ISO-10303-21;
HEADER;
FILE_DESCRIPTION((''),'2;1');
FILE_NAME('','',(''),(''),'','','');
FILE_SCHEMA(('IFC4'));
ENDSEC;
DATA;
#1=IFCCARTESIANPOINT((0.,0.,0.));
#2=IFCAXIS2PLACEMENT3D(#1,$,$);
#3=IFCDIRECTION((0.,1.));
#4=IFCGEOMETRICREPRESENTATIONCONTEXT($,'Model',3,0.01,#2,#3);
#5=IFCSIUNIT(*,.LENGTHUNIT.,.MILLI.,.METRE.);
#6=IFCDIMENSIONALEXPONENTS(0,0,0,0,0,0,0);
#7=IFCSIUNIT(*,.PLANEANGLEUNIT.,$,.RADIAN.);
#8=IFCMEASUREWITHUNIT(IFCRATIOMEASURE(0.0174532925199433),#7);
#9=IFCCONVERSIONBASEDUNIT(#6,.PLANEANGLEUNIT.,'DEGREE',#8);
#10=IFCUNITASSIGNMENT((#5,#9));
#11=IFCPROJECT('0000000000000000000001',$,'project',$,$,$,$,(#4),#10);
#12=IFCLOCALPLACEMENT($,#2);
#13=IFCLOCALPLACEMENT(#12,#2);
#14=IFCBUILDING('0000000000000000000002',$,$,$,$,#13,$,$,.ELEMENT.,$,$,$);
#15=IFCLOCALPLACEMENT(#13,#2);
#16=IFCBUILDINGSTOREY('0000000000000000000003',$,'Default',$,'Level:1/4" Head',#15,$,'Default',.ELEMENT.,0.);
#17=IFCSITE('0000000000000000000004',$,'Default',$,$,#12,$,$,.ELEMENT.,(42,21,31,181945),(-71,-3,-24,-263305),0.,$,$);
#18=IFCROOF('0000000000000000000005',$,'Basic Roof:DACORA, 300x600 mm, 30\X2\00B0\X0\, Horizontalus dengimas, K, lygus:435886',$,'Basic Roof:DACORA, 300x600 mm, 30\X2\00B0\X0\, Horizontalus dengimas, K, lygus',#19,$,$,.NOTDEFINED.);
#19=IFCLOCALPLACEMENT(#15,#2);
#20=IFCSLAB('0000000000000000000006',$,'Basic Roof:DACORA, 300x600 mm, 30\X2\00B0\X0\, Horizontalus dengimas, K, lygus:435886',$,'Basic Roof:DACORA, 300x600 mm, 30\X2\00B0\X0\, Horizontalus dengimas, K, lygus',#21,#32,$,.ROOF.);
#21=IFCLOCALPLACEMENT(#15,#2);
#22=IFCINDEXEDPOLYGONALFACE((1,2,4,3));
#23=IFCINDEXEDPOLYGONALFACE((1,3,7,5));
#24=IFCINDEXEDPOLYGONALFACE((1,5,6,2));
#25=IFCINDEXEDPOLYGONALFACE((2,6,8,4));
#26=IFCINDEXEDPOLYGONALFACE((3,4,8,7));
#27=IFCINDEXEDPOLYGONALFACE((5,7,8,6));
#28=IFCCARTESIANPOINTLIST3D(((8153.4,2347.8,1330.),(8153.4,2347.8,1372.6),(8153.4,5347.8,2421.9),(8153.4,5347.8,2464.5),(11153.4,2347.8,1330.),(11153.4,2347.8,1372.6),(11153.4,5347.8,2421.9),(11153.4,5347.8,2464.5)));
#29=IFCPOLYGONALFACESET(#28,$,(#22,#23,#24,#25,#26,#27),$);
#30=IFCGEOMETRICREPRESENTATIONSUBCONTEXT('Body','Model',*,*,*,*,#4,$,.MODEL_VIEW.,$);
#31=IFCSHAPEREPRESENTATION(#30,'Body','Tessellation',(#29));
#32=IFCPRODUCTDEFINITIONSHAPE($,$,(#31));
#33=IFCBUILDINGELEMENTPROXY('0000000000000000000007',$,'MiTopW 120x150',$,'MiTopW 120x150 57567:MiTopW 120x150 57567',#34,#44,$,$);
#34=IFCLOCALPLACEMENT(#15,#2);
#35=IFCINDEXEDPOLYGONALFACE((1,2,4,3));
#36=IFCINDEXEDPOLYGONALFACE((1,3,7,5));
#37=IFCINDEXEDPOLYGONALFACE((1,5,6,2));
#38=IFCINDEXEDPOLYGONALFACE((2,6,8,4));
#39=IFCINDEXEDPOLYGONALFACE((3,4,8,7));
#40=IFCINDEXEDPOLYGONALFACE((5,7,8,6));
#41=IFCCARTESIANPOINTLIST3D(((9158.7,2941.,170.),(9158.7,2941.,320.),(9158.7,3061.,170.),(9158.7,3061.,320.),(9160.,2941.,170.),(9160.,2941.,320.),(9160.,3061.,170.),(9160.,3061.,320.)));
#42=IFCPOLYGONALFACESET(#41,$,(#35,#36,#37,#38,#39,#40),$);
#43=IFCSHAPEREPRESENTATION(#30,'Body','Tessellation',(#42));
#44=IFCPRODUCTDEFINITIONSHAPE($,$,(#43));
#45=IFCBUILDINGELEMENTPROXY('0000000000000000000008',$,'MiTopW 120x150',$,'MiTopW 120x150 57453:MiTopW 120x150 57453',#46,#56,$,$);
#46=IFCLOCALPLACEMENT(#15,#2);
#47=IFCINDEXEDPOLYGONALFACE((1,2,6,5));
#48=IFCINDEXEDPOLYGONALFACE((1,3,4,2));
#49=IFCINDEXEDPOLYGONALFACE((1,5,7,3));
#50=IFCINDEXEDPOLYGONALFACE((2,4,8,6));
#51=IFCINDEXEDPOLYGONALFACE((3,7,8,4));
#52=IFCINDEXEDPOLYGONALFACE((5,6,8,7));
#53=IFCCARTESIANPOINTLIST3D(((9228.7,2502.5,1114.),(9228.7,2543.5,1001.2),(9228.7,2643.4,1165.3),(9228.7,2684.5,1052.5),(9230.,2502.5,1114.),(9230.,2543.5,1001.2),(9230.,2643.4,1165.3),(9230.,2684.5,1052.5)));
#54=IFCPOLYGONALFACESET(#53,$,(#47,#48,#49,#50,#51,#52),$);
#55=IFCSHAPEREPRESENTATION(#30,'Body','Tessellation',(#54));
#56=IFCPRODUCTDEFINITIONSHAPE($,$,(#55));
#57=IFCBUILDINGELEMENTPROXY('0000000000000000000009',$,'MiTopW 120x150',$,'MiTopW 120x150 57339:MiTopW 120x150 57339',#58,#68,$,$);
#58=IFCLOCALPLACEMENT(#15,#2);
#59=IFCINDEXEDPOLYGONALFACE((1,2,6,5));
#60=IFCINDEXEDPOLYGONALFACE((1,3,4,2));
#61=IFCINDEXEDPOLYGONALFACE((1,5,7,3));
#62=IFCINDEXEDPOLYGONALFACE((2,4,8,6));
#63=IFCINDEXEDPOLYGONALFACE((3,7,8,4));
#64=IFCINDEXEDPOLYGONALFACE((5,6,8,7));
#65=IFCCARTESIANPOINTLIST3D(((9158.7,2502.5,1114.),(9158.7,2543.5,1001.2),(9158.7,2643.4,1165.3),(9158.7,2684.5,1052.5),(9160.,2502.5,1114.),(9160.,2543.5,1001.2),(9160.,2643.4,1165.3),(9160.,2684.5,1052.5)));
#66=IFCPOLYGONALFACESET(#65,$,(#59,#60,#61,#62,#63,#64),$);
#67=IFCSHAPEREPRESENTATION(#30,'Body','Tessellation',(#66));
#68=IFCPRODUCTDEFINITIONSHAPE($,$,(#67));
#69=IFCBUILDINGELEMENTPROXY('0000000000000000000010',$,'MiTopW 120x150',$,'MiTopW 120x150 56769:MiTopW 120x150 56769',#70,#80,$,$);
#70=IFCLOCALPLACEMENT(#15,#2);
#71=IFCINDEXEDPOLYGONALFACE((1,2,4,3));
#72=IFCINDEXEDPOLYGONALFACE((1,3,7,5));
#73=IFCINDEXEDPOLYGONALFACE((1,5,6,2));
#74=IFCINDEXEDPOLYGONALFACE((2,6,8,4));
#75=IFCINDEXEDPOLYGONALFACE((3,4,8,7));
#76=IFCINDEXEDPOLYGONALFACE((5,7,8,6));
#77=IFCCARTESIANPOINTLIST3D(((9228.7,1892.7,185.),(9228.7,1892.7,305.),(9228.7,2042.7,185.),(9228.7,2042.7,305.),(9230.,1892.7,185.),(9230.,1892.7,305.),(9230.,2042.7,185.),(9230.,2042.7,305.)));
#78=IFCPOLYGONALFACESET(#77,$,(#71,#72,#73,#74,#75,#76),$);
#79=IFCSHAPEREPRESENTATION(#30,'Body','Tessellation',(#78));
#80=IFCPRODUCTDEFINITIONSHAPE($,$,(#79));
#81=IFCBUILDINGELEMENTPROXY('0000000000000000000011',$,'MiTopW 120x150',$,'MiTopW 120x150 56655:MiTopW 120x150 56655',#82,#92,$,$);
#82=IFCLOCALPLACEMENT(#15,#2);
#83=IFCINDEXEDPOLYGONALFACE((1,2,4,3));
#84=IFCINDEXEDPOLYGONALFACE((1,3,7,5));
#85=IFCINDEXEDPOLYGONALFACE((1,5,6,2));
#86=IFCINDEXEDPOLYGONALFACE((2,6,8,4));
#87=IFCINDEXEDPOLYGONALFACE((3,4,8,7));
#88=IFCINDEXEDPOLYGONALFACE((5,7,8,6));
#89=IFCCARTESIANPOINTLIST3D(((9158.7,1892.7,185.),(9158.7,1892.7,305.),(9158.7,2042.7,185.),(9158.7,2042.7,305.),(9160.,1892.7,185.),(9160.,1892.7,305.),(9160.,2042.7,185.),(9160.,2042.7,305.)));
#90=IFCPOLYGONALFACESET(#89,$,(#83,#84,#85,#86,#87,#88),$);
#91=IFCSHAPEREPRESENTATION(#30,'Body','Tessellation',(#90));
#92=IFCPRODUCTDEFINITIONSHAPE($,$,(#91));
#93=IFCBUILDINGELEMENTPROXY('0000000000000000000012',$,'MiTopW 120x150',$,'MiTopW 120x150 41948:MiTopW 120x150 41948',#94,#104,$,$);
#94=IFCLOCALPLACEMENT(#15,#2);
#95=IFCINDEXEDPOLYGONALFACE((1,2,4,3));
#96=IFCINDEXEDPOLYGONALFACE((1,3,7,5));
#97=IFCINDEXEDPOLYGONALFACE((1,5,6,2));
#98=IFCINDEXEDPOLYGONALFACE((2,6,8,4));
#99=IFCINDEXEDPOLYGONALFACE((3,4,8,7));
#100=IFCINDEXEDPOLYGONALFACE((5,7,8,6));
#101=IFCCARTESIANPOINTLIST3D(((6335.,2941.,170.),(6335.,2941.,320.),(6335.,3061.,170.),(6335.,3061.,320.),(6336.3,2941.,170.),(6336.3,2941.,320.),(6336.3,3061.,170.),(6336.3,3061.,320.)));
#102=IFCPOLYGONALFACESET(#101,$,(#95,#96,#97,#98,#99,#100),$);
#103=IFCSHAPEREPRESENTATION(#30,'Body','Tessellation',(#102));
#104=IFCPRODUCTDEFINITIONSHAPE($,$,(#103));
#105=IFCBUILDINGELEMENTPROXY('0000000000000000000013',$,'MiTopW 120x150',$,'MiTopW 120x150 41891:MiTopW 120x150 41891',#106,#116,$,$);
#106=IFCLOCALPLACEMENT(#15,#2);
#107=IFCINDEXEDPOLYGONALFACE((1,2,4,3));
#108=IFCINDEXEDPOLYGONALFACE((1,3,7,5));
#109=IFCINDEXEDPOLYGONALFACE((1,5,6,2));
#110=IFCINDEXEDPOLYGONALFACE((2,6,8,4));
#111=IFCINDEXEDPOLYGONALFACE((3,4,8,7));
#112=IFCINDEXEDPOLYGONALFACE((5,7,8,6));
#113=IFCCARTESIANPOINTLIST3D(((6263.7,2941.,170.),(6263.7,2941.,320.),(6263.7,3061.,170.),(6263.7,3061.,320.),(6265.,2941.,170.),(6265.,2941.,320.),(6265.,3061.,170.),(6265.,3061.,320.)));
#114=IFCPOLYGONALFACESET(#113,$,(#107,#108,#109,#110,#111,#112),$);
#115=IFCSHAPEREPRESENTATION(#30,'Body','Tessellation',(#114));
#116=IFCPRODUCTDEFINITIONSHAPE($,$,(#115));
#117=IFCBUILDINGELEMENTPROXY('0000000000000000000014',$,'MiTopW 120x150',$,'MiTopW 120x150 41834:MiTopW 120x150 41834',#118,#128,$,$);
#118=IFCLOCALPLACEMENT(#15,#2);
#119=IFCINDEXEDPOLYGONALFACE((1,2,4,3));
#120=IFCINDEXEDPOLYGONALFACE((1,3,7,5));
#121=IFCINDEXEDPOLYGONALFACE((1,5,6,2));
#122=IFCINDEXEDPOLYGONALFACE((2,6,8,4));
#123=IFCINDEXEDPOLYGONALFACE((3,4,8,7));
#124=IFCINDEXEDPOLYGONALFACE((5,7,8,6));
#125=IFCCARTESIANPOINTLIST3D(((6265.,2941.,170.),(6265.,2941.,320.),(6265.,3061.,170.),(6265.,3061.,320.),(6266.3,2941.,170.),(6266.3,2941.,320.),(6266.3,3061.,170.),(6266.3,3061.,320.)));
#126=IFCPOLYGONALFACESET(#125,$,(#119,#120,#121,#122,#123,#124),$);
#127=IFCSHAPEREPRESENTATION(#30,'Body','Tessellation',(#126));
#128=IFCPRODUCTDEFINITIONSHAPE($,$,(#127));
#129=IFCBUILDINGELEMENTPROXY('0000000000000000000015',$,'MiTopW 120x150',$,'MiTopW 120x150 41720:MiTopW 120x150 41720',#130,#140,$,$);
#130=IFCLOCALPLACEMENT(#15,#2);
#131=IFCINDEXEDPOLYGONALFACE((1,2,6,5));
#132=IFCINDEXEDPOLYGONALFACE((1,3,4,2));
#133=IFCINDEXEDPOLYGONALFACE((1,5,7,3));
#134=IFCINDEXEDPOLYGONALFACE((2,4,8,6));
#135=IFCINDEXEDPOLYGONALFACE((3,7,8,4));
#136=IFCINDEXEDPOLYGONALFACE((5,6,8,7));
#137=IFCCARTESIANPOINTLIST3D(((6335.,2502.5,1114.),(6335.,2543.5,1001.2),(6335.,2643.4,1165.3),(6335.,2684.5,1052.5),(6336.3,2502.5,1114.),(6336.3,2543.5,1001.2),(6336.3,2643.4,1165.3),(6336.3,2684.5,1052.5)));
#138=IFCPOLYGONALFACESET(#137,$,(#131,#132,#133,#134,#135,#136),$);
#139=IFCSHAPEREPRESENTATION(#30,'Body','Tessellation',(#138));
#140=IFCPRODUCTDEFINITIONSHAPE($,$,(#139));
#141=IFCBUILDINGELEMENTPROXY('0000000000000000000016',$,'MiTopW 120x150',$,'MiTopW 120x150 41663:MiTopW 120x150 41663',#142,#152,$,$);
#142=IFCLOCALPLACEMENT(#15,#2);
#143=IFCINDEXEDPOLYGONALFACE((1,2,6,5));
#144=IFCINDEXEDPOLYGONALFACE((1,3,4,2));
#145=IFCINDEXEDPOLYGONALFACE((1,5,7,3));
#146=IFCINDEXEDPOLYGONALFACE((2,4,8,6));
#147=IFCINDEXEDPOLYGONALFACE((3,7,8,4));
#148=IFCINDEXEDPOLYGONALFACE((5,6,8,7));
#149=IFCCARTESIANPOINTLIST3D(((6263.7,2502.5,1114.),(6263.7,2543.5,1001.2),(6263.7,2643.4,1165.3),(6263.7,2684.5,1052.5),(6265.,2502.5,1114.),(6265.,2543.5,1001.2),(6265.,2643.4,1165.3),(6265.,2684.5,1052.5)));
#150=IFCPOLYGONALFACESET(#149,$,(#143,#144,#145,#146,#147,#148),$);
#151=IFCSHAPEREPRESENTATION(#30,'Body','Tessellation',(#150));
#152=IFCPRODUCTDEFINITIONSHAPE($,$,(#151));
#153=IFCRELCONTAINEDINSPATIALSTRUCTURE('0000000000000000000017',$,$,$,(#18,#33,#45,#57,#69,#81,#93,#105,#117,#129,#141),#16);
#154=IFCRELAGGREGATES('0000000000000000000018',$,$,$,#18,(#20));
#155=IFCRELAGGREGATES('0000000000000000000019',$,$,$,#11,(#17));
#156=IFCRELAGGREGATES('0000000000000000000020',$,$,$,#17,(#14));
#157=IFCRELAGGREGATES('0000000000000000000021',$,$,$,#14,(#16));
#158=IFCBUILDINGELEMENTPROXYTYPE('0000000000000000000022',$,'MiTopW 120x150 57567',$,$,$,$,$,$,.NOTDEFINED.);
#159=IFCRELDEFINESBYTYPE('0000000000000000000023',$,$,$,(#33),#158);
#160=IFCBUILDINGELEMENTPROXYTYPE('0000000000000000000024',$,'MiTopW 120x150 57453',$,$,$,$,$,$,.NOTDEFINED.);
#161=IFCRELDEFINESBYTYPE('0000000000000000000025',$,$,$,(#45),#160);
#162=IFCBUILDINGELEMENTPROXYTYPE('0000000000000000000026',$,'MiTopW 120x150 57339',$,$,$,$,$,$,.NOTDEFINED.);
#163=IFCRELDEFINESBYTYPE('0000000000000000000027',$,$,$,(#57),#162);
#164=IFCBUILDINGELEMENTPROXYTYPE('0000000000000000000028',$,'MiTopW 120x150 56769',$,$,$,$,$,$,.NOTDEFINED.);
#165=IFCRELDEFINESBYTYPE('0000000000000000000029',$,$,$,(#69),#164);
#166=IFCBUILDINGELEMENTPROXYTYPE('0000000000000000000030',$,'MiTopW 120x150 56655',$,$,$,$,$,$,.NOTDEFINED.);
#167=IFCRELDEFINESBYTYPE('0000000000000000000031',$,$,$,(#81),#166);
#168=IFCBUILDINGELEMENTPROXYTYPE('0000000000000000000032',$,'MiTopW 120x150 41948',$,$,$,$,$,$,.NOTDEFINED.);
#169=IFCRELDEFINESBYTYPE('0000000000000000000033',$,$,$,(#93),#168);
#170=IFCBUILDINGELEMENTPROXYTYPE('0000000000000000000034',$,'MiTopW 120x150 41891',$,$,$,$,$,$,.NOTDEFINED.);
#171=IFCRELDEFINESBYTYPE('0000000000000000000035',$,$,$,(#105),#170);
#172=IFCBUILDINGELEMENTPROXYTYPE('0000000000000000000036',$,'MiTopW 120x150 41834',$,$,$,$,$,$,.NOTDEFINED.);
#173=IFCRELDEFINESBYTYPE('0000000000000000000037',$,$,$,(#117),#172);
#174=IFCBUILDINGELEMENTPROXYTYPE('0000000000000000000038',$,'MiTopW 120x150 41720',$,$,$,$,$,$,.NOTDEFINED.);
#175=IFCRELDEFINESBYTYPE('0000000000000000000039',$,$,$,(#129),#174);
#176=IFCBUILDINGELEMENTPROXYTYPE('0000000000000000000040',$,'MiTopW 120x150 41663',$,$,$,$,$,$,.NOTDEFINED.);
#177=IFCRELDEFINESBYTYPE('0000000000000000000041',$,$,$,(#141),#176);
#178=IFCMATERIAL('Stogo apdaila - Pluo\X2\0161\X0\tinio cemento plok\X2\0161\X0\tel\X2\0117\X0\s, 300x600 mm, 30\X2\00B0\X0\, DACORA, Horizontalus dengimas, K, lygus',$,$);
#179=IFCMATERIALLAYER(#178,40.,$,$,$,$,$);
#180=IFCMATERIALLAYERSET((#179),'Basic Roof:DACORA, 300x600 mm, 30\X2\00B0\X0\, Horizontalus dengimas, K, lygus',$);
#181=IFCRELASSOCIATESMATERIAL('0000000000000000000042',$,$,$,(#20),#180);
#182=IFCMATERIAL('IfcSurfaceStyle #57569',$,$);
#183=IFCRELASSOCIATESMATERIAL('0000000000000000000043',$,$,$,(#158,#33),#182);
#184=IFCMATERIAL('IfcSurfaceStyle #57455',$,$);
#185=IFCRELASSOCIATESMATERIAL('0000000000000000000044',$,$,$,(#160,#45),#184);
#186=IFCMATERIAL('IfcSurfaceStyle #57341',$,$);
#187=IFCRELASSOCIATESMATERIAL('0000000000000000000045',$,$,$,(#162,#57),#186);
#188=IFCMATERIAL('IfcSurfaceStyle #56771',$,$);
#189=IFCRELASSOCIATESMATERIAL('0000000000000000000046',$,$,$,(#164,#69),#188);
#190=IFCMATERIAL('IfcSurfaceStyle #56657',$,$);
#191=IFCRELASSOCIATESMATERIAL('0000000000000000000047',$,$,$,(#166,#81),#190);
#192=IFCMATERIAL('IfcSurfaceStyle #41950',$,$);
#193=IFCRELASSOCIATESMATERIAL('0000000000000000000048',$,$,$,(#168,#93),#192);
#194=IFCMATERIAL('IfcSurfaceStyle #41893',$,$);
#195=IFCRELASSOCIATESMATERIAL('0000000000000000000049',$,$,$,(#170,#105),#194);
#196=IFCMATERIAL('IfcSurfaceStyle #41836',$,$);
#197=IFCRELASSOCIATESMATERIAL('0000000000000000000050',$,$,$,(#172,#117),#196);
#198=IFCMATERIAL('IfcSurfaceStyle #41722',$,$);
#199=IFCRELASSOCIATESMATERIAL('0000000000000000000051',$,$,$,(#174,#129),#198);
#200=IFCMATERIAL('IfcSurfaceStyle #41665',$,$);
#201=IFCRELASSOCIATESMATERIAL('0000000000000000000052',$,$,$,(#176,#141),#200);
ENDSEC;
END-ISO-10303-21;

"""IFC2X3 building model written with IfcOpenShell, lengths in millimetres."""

from ifc_helpers import new_model, entity, si_unit, converted_unit, direction, frame, frame_2d, origin, origin_2d_with_axis, place, context, subcontext, project, spatial, polyline, rectangle, outline, extrude, source, transform, mapped, material, layer, layer_set, type_object, type_shapes, element, aggregate, save


model = new_model("IFC2X3")

# Units and contexts
model_context = context("Model", 3, precision=0.01, world=origin(), true_north=direction((0.0, 1.0)))
body_context = subcontext(model_context, "Body", "Model", "MODEL_VIEW")
ifc_project = project(units=[si_unit("LENGTHUNIT", "METRE", prefix="MILLI"), converted_unit("PLANEANGLEUNIT", "DEGREE", entity("IfcRatioMeasure", 0.0174532925199433), si_unit("PLANEANGLEUNIT", "RADIAN"), dimensions=[0, 0, 0, 0, 0, 0, 0])], contexts=[model_context])

# Site, building, storey
site_placement = place(None, origin())
site = spatial("IfcSite", under=ifc_project, at=site_placement, Name="Default", CompositionType="ELEMENT", RefLatitude=(42, 21, 31, 181945), RefLongitude=(-71, -3, -24, -263305), RefElevation=0.0)
building_placement = place(site_placement, origin())
building = spatial("IfcBuilding", under=site, at=building_placement, CompositionType="ELEMENT")
storey_placement = place(building_placement, origin())
storey = spatial("IfcBuildingStorey", under=building, at=storey_placement, Name="Default", ObjectType="Level:1/4\" Head", LongName="Default", CompositionType="ELEMENT", Elevation=0.0)

# Roof, slab
roof_placement = place(storey_placement, frame((8153.4, 2347.8, 1330.0)))
roof = element("IfcRoof", 1, at=roof_placement, inside=storey, Name="Basic Roof:DACORA, 300x600 mm, 30°, Horizontalus dengimas, K, lygus:435886", ObjectType="Basic Roof:DACORA, 300x600 mm, 30°, Horizontalus dengimas, K, lygus", ShapeType="NOTDEFINED")
ifc_material_1 = material(Name="Stogo apdaila - Pluoštinio cemento plokštelės, 300x600 mm, 30°, DACORA, Horizontalus dengimas, K, lygus")
ifc_layer = layer(ifc_material_1, 40.0)
ifc_layer_set = layer_set([ifc_layer], Name="Basic Roof:DACORA, 300x600 mm, 30°, Horizontalus dengimas, K, lygus")
slab_placement = place(roof_placement, origin())
slab = element("IfcSlab", 2, at=slab_placement, material=ifc_layer_set, Name="Basic Roof:DACORA, 300x600 mm, 30°, Horizontalus dengimas, K, lygus:435886", ObjectType="Basic Roof:DACORA, 300x600 mm, 30°, Horizontalus dengimas, K, lygus", PredefinedType="ROOF", context=body_context, shape_type="SweptSolid", body=[
    extrude(rectangle(XDim=3192.5, YDim=3000.0, at=frame_2d((0.0, 0.0), x_axis=(0.0, -1.0))), frame((1500.0, 1500.0, 546.0), z_axis=(0.0, -0.34202, 0.939693), x_axis=(1.0, 0.0, 0.0)), (0.0, 0.34202, 0.939693), 42.6),
])
aggregate(roof, [slab])

# Building element proxies
ifc_material_2 = material(Name="IfcSurfaceStyle #57569")
building_element_proxy_type_1 = type_object("IfcBuildingElementProxyType", Name="MiTopW 120x150 57567", PredefinedType="NOTDEFINED", material=ifc_material_2)
shared_shape_1 = source(origin(), body_context, "Body", "SweptSolid", [
    extrude(rectangle(XDim=150.0, YDim=120.0, at=frame_2d((0.0, 0.0), x_axis=(1.0, 0.0))), frame((75.0, 60.0, 0.0), z_axis=(0.0, 0.0, 1.0), x_axis=(-1.0, 0.0, 0.0)), (0.0, 0.0, 1.0), 1.3),
])
type_shapes(building_element_proxy_type_1, [shared_shape_1])
proxy_1_placement = place(building_placement, frame((9160.0, 2941.0, 170.0), z_axis=(-1.0, 0.0, 0.0), x_axis=(0.0, 0.0, 1.0)))
element("IfcBuildingElementProxy", 3, at=proxy_1_placement, inside=storey, type_object=building_element_proxy_type_1, material=ifc_material_2, Name="MiTopW 120x150", ObjectType="MiTopW 120x150 57567:MiTopW 120x150 57567", context=body_context, shape_type="MappedRepresentation", body=[
    mapped(shared_shape_1, transform((0.0, 0.0, 0.0), scale=1.0)),
])
ifc_material_3 = material(Name="IfcSurfaceStyle #57455")
building_element_proxy_type_2 = type_object("IfcBuildingElementProxyType", Name="MiTopW 120x150 57453", PredefinedType="NOTDEFINED", material=ifc_material_3)
shared_shape_2 = source(origin(), body_context, "Body", "SweptSolid", [
    extrude(outline(polyline([(-75.0, -60.0), (75.0, -60.0), (75.0, 60.0), (-75.0, 60.0), (-75.0, -60.0)])), frame((75.0, 60.0, 0.0), z_axis=(0.0, 0.0, 1.0), x_axis=(-1.0, 0.0, 0.0)), (0.0, 0.0, 1.0), 1.3),
])
type_shapes(building_element_proxy_type_2, [shared_shape_2])
proxy_2_placement = place(building_placement, frame((9230.0, 2502.5, 1114.0), z_axis=(-1.0, 0.0, 0.0), x_axis=(0.0, 0.939693, 0.34202)))
element("IfcBuildingElementProxy", 4, at=proxy_2_placement, inside=storey, type_object=building_element_proxy_type_2, material=ifc_material_3, Name="MiTopW 120x150", ObjectType="MiTopW 120x150 57453:MiTopW 120x150 57453", context=body_context, shape_type="MappedRepresentation", body=[
    mapped(shared_shape_2, transform((0.0, 0.0, 0.0), scale=1.0)),
])
ifc_material_4 = material(Name="IfcSurfaceStyle #57341")
building_element_proxy_type_3 = type_object("IfcBuildingElementProxyType", Name="MiTopW 120x150 57339", PredefinedType="NOTDEFINED", material=ifc_material_4)
shared_shape_3 = source(origin(), body_context, "Body", "SweptSolid", [
    extrude(outline(polyline([(-75.0, -60.0), (75.0, -60.0), (75.0, 60.0), (-75.0, 60.0), (-75.0, -60.0)])), frame((75.0, 60.0, 0.0), z_axis=(0.0, 0.0, 1.0), x_axis=(-1.0, 0.0, 0.0)), (0.0, 0.0, 1.0), 1.3),
])
type_shapes(building_element_proxy_type_3, [shared_shape_3])
proxy_3_placement = place(building_placement, frame((9160.0, 2502.5, 1114.0), z_axis=(-1.0, 0.0, 0.0), x_axis=(0.0, 0.939693, 0.34202)))
element("IfcBuildingElementProxy", 5, at=proxy_3_placement, inside=storey, type_object=building_element_proxy_type_3, material=ifc_material_4, Name="MiTopW 120x150", ObjectType="MiTopW 120x150 57339:MiTopW 120x150 57339", context=body_context, shape_type="MappedRepresentation", body=[
    mapped(shared_shape_3, transform((0.0, 0.0, 0.0), scale=1.0)),
])
ifc_material_5 = material(Name="IfcSurfaceStyle #56771")
building_element_proxy_type_4 = type_object("IfcBuildingElementProxyType", Name="MiTopW 120x150 56769", PredefinedType="NOTDEFINED", material=ifc_material_5)
shared_shape_4 = source(origin(), body_context, "Body", "SweptSolid", [
    extrude(rectangle(XDim=150.0, YDim=120.0, at=origin_2d_with_axis()), frame((75.0, 60.0, 0.0), z_axis=(0.0, 0.0, 1.0), x_axis=(-1.0, 0.0, 0.0)), (0.0, 0.0, 1.0), 1.3),
])
type_shapes(building_element_proxy_type_4, [shared_shape_4])
proxy_4_placement = place(building_placement, frame((9230.0, 1892.7, 305.0), z_axis=(-1.0, 0.0, 0.0), x_axis=(0.0, 1.0, 0.0)))
element("IfcBuildingElementProxy", 6, at=proxy_4_placement, inside=storey, type_object=building_element_proxy_type_4, material=ifc_material_5, Name="MiTopW 120x150", ObjectType="MiTopW 120x150 56769:MiTopW 120x150 56769", context=body_context, shape_type="MappedRepresentation", body=[
    mapped(shared_shape_4, transform((0.0, 0.0, 0.0), scale=1.0)),
])
ifc_material_6 = material(Name="IfcSurfaceStyle #56657")
building_element_proxy_type_5 = type_object("IfcBuildingElementProxyType", Name="MiTopW 120x150 56655", PredefinedType="NOTDEFINED", material=ifc_material_6)
shared_shape_5 = source(origin(), body_context, "Body", "SweptSolid", [
    extrude(rectangle(XDim=150.0, YDim=120.0, at=origin_2d_with_axis()), frame((75.0, 60.0, 0.0), z_axis=(0.0, 0.0, 1.0), x_axis=(-1.0, 0.0, 0.0)), (0.0, 0.0, 1.0), 1.3),
])
type_shapes(building_element_proxy_type_5, [shared_shape_5])
proxy_5_placement = place(building_placement, frame((9160.0, 1892.7, 305.0), z_axis=(-1.0, 0.0, 0.0), x_axis=(0.0, 1.0, 0.0)))
element("IfcBuildingElementProxy", 7, at=proxy_5_placement, inside=storey, type_object=building_element_proxy_type_5, material=ifc_material_6, Name="MiTopW 120x150", ObjectType="MiTopW 120x150 56655:MiTopW 120x150 56655", context=body_context, shape_type="MappedRepresentation", body=[
    mapped(shared_shape_5, transform((0.0, 0.0, 0.0), scale=1.0)),
])
ifc_material_7 = material(Name="IfcSurfaceStyle #41950")
building_element_proxy_type_6 = type_object("IfcBuildingElementProxyType", Name="MiTopW 120x150 41948", PredefinedType="NOTDEFINED", material=ifc_material_7)
shared_shape_6 = source(origin(), body_context, "Body", "SweptSolid", [
    extrude(rectangle(XDim=150.0, YDim=120.0, at=frame_2d((0.0, 0.0), x_axis=(1.0, 0.0))), frame((75.0, 60.0, 0.0), z_axis=(0.0, 0.0, 1.0), x_axis=(-1.0, 0.0, 0.0)), (0.0, 0.0, 1.0), 1.3),
])
type_shapes(building_element_proxy_type_6, [shared_shape_6])
proxy_6_placement = place(building_placement, frame((6336.3, 2941.0, 170.0), z_axis=(-1.0, 0.0, 0.0), x_axis=(0.0, 0.0, 1.0)))
element("IfcBuildingElementProxy", 8, at=proxy_6_placement, inside=storey, type_object=building_element_proxy_type_6, material=ifc_material_7, Name="MiTopW 120x150", ObjectType="MiTopW 120x150 41948:MiTopW 120x150 41948", context=body_context, shape_type="MappedRepresentation", body=[
    mapped(shared_shape_6, transform((0.0, 0.0, 0.0), scale=1.0)),
])
ifc_material_8 = material(Name="IfcSurfaceStyle #41893")
building_element_proxy_type_7 = type_object("IfcBuildingElementProxyType", Name="MiTopW 120x150 41891", PredefinedType="NOTDEFINED", material=ifc_material_8)
shared_shape_7 = source(origin(), body_context, "Body", "SweptSolid", [
    extrude(rectangle(XDim=150.0, YDim=120.0, at=frame_2d((0.0, 0.0), x_axis=(1.0, 0.0))), frame((75.0, 60.0, 0.0), z_axis=(0.0, 0.0, 1.0), x_axis=(-1.0, 0.0, 0.0)), (0.0, 0.0, 1.0), 1.3),
])
type_shapes(building_element_proxy_type_7, [shared_shape_7])
proxy_7_placement = place(building_placement, frame((6265.0, 2941.0, 170.0), z_axis=(-1.0, 0.0, 0.0), x_axis=(0.0, 0.0, 1.0)))
element("IfcBuildingElementProxy", 9, at=proxy_7_placement, inside=storey, type_object=building_element_proxy_type_7, material=ifc_material_8, Name="MiTopW 120x150", ObjectType="MiTopW 120x150 41891:MiTopW 120x150 41891", context=body_context, shape_type="MappedRepresentation", body=[
    mapped(shared_shape_7, transform((0.0, 0.0, 0.0), scale=1.0)),
])
ifc_material_9 = material(Name="IfcSurfaceStyle #41836")
building_element_proxy_type_8 = type_object("IfcBuildingElementProxyType", Name="MiTopW 120x150 41834", PredefinedType="NOTDEFINED", material=ifc_material_9)
shared_shape_8 = source(origin(), body_context, "Body", "SweptSolid", [
    extrude(rectangle(XDim=150.0, YDim=120.0, at=frame_2d((0.0, 0.0), x_axis=(1.0, 0.0))), frame((75.0, 60.0, 0.0), z_axis=(0.0, 0.0, 1.0), x_axis=(-1.0, 0.0, 0.0)), (0.0, 0.0, 1.0), 1.3),
])
type_shapes(building_element_proxy_type_8, [shared_shape_8])
proxy_8_placement = place(building_placement, frame((6266.3, 2941.0, 170.0), z_axis=(-1.0, 0.0, 0.0), x_axis=(0.0, 0.0, 1.0)))
element("IfcBuildingElementProxy", 10, at=proxy_8_placement, inside=storey, type_object=building_element_proxy_type_8, material=ifc_material_9, Name="MiTopW 120x150", ObjectType="MiTopW 120x150 41834:MiTopW 120x150 41834", context=body_context, shape_type="MappedRepresentation", body=[
    mapped(shared_shape_8, transform((0.0, 0.0, 0.0), scale=1.0)),
])
ifc_material_10 = material(Name="IfcSurfaceStyle #41722")
building_element_proxy_type_9 = type_object("IfcBuildingElementProxyType", Name="MiTopW 120x150 41720", PredefinedType="NOTDEFINED", material=ifc_material_10)
shared_shape_9 = source(origin(), body_context, "Body", "SweptSolid", [
    extrude(outline(polyline([(-75.0, -60.0), (75.0, -60.0), (75.0, 60.0), (-75.0, 60.0), (-75.0, -60.0)])), frame((75.0, 60.0, 0.0), z_axis=(0.0, 0.0, 1.0), x_axis=(-1.0, 0.0, 0.0)), (0.0, 0.0, 1.0), 1.3),
])
type_shapes(building_element_proxy_type_9, [shared_shape_9])
proxy_9_placement = place(building_placement, frame((6336.3, 2502.5, 1114.0), z_axis=(-1.0, 0.0, 0.0), x_axis=(0.0, 0.939693, 0.34202)))
element("IfcBuildingElementProxy", 11, at=proxy_9_placement, inside=storey, type_object=building_element_proxy_type_9, material=ifc_material_10, Name="MiTopW 120x150", ObjectType="MiTopW 120x150 41720:MiTopW 120x150 41720", context=body_context, shape_type="MappedRepresentation", body=[
    mapped(shared_shape_9, transform((0.0, 0.0, 0.0), scale=1.0)),
])
ifc_material_11 = material(Name="IfcSurfaceStyle #41665")
building_element_proxy_type_10 = type_object("IfcBuildingElementProxyType", Name="MiTopW 120x150 41663", PredefinedType="NOTDEFINED", material=ifc_material_11)
shared_shape_10 = source(origin(), body_context, "Body", "SweptSolid", [
    extrude(outline(polyline([(-75.0, -60.0), (75.0, -60.0), (75.0, 60.0), (-75.0, 60.0), (-75.0, -60.0)])), frame((75.0, 60.0, 0.0), z_axis=(0.0, 0.0, 1.0), x_axis=(-1.0, 0.0, 0.0)), (0.0, 0.0, 1.0), 1.3),
])
type_shapes(building_element_proxy_type_10, [shared_shape_10])
proxy_10_placement = place(building_placement, frame((6265.0, 2502.5, 1114.0), z_axis=(-1.0, 0.0, 0.0), x_axis=(0.0, 0.939693, 0.34202)))
element("IfcBuildingElementProxy", 12, at=proxy_10_placement, inside=storey, type_object=building_element_proxy_type_10, material=ifc_material_11, Name="MiTopW 120x150", ObjectType="MiTopW 120x150 41663:MiTopW 120x150 41663", context=body_context, shape_type="MappedRepresentation", body=[
    mapped(shared_shape_10, transform((0.0, 0.0, 0.0), scale=1.0)),
])

save(model, "model.ifc")
